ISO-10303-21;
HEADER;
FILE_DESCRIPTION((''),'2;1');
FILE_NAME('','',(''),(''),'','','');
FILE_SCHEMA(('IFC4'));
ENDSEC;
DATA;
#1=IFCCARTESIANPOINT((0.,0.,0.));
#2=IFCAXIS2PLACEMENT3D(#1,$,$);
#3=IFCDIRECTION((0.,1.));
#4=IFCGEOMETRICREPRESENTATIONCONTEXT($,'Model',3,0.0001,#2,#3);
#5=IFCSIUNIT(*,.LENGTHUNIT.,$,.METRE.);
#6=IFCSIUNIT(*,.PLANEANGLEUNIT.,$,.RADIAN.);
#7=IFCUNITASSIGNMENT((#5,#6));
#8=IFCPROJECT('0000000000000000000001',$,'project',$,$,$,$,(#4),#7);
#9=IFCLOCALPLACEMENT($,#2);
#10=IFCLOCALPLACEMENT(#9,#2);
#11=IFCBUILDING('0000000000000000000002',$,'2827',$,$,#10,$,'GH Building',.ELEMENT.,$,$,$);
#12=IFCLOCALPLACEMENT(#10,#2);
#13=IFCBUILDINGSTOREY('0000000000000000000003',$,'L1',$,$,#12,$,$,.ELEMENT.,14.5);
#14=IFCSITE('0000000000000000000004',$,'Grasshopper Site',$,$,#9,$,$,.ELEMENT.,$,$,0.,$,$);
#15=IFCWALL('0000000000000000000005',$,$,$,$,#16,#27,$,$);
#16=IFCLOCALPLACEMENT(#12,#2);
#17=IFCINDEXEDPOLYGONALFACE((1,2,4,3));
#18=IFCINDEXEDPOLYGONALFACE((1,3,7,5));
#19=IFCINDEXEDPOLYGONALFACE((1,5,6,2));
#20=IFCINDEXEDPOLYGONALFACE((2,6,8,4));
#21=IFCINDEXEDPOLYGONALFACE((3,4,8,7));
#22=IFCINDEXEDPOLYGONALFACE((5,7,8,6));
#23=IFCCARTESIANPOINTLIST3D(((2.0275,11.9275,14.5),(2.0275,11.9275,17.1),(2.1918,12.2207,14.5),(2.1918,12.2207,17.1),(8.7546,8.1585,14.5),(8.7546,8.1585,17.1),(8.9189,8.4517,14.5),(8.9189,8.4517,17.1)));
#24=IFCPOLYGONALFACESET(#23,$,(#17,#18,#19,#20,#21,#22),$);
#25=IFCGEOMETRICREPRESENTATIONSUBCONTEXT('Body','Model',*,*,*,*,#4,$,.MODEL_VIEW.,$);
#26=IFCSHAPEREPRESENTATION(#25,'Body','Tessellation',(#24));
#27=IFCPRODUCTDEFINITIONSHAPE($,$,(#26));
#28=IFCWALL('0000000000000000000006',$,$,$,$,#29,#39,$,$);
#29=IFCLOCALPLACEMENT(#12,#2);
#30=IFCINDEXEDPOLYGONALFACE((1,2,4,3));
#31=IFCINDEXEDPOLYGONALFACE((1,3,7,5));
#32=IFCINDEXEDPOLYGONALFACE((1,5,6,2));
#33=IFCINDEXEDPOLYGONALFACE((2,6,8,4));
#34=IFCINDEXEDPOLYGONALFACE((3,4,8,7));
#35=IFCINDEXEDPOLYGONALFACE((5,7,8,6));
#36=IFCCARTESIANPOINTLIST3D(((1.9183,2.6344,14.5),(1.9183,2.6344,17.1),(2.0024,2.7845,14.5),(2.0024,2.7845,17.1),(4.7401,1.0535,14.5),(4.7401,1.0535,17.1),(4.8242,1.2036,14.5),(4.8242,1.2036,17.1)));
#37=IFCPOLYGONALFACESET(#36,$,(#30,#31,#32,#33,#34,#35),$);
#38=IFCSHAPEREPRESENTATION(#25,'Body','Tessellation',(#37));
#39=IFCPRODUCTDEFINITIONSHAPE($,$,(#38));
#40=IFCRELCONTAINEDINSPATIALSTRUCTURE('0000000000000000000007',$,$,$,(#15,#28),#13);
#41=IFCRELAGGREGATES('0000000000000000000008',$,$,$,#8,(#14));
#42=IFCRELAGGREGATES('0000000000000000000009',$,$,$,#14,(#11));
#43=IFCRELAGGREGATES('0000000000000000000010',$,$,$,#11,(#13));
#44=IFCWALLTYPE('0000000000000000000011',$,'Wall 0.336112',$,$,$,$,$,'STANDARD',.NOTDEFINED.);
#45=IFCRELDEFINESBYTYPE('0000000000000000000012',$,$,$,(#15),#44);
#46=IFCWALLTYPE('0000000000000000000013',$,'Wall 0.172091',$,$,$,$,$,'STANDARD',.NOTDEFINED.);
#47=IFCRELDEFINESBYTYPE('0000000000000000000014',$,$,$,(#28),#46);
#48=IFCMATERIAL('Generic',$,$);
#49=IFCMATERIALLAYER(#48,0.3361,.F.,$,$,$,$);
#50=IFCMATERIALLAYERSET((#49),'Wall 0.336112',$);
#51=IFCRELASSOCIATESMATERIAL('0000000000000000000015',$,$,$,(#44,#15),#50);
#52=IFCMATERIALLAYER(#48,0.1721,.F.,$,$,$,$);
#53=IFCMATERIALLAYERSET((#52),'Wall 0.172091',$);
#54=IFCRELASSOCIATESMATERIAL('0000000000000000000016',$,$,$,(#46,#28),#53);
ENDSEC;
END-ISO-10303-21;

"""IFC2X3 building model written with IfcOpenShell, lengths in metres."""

from ifc_helpers import new_model, si_unit, direction, frame, frame_2d, origin, place, context, subcontext, project, spatial, rectangle, extrude, material, layer, layer_set, layer_usage, type_object, element, save


model = new_model("IFC2X3")

# Units and contexts
model_context = context("Model", 3, precision=0.0001, world=origin(), true_north=direction((0.0, 1.0)))
body_context = subcontext(model_context, "Body", "Model", "MODEL_VIEW")
ifc_project = project(units=[si_unit("LENGTHUNIT", "METRE"), si_unit("PLANEANGLEUNIT", "RADIAN")], contexts=[model_context])

# Site, building, storey
site_placement = place(None, origin())
site = spatial("IfcSite", under=ifc_project, at=site_placement, Name="Grasshopper Site", CompositionType="ELEMENT", RefElevation=0.0)
building_placement = place(site_placement, origin())
building = spatial("IfcBuilding", under=site, at=building_placement, Name="2827", LongName="GH Building", CompositionType="ELEMENT")
storey_placement = place(building_placement, origin())
storey = spatial("IfcBuildingStorey", under=building, at=storey_placement, Name="L1", CompositionType="ELEMENT", Elevation=14.5)

# Shared definitions
ifc_material = material(Name="Generic")

# Wall
ifc_layer_1 = layer(ifc_material, 0.3361, ventilated=False)
ifc_layer_set_1 = layer_set([ifc_layer_1], Name="Wall 0.336112")
ifc_layer_usage_1 = layer_usage(ifc_layer_set_1, "AXIS2", "NEGATIVE", 0.1681)
wall_type_1 = type_object("IfcWallType", Name="Wall 0.336112", ElementType="STANDARD", PredefinedType="NOTDEFINED", material=ifc_layer_set_1)
wall_1_placement = place(storey_placement, frame((2.1096, 12.0741, 14.5), z_axis=(0.0, 0.0, 1.0), x_axis=(0.872406, -0.488782, 0.0)))
element("IfcWall", 1, at=wall_1_placement, inside=storey, type_object=wall_type_1, material=ifc_layer_usage_1, context=body_context, shape_type="SweptSolid", body=[
    extrude(rectangle(XDim=7.711, YDim=0.3361, at=frame_2d((3.8555, 0.0))), origin(), (0.0, 0.0, 1.0), 2.6),
])

# Wall
ifc_layer_2 = layer(ifc_material, 0.1721, ventilated=False)
ifc_layer_set_2 = layer_set([ifc_layer_2], Name="Wall 0.172091")
ifc_layer_usage_2 = layer_usage(ifc_layer_set_2, "AXIS2", "NEGATIVE", 0.086)
wall_type_2 = type_object("IfcWallType", Name="Wall 0.172091", ElementType="STANDARD", PredefinedType="NOTDEFINED", material=ifc_layer_set_2)
wall_2_placement = place(storey_placement, frame((1.9604, 2.7095, 14.5), z_axis=(0.0, 0.0, 1.0), x_axis=(0.872406, -0.488782, 0.0)))
element("IfcWall", 2, at=wall_2_placement, inside=storey, type_object=wall_type_2, material=ifc_layer_usage_2, context=body_context, shape_type="SweptSolid", body=[
    extrude(rectangle(XDim=3.2345, YDim=0.1721, at=frame_2d((1.6172, 0.0))), origin(), (0.0, 0.0, 1.0), 2.6),
])

save(model, "model.ifc")
